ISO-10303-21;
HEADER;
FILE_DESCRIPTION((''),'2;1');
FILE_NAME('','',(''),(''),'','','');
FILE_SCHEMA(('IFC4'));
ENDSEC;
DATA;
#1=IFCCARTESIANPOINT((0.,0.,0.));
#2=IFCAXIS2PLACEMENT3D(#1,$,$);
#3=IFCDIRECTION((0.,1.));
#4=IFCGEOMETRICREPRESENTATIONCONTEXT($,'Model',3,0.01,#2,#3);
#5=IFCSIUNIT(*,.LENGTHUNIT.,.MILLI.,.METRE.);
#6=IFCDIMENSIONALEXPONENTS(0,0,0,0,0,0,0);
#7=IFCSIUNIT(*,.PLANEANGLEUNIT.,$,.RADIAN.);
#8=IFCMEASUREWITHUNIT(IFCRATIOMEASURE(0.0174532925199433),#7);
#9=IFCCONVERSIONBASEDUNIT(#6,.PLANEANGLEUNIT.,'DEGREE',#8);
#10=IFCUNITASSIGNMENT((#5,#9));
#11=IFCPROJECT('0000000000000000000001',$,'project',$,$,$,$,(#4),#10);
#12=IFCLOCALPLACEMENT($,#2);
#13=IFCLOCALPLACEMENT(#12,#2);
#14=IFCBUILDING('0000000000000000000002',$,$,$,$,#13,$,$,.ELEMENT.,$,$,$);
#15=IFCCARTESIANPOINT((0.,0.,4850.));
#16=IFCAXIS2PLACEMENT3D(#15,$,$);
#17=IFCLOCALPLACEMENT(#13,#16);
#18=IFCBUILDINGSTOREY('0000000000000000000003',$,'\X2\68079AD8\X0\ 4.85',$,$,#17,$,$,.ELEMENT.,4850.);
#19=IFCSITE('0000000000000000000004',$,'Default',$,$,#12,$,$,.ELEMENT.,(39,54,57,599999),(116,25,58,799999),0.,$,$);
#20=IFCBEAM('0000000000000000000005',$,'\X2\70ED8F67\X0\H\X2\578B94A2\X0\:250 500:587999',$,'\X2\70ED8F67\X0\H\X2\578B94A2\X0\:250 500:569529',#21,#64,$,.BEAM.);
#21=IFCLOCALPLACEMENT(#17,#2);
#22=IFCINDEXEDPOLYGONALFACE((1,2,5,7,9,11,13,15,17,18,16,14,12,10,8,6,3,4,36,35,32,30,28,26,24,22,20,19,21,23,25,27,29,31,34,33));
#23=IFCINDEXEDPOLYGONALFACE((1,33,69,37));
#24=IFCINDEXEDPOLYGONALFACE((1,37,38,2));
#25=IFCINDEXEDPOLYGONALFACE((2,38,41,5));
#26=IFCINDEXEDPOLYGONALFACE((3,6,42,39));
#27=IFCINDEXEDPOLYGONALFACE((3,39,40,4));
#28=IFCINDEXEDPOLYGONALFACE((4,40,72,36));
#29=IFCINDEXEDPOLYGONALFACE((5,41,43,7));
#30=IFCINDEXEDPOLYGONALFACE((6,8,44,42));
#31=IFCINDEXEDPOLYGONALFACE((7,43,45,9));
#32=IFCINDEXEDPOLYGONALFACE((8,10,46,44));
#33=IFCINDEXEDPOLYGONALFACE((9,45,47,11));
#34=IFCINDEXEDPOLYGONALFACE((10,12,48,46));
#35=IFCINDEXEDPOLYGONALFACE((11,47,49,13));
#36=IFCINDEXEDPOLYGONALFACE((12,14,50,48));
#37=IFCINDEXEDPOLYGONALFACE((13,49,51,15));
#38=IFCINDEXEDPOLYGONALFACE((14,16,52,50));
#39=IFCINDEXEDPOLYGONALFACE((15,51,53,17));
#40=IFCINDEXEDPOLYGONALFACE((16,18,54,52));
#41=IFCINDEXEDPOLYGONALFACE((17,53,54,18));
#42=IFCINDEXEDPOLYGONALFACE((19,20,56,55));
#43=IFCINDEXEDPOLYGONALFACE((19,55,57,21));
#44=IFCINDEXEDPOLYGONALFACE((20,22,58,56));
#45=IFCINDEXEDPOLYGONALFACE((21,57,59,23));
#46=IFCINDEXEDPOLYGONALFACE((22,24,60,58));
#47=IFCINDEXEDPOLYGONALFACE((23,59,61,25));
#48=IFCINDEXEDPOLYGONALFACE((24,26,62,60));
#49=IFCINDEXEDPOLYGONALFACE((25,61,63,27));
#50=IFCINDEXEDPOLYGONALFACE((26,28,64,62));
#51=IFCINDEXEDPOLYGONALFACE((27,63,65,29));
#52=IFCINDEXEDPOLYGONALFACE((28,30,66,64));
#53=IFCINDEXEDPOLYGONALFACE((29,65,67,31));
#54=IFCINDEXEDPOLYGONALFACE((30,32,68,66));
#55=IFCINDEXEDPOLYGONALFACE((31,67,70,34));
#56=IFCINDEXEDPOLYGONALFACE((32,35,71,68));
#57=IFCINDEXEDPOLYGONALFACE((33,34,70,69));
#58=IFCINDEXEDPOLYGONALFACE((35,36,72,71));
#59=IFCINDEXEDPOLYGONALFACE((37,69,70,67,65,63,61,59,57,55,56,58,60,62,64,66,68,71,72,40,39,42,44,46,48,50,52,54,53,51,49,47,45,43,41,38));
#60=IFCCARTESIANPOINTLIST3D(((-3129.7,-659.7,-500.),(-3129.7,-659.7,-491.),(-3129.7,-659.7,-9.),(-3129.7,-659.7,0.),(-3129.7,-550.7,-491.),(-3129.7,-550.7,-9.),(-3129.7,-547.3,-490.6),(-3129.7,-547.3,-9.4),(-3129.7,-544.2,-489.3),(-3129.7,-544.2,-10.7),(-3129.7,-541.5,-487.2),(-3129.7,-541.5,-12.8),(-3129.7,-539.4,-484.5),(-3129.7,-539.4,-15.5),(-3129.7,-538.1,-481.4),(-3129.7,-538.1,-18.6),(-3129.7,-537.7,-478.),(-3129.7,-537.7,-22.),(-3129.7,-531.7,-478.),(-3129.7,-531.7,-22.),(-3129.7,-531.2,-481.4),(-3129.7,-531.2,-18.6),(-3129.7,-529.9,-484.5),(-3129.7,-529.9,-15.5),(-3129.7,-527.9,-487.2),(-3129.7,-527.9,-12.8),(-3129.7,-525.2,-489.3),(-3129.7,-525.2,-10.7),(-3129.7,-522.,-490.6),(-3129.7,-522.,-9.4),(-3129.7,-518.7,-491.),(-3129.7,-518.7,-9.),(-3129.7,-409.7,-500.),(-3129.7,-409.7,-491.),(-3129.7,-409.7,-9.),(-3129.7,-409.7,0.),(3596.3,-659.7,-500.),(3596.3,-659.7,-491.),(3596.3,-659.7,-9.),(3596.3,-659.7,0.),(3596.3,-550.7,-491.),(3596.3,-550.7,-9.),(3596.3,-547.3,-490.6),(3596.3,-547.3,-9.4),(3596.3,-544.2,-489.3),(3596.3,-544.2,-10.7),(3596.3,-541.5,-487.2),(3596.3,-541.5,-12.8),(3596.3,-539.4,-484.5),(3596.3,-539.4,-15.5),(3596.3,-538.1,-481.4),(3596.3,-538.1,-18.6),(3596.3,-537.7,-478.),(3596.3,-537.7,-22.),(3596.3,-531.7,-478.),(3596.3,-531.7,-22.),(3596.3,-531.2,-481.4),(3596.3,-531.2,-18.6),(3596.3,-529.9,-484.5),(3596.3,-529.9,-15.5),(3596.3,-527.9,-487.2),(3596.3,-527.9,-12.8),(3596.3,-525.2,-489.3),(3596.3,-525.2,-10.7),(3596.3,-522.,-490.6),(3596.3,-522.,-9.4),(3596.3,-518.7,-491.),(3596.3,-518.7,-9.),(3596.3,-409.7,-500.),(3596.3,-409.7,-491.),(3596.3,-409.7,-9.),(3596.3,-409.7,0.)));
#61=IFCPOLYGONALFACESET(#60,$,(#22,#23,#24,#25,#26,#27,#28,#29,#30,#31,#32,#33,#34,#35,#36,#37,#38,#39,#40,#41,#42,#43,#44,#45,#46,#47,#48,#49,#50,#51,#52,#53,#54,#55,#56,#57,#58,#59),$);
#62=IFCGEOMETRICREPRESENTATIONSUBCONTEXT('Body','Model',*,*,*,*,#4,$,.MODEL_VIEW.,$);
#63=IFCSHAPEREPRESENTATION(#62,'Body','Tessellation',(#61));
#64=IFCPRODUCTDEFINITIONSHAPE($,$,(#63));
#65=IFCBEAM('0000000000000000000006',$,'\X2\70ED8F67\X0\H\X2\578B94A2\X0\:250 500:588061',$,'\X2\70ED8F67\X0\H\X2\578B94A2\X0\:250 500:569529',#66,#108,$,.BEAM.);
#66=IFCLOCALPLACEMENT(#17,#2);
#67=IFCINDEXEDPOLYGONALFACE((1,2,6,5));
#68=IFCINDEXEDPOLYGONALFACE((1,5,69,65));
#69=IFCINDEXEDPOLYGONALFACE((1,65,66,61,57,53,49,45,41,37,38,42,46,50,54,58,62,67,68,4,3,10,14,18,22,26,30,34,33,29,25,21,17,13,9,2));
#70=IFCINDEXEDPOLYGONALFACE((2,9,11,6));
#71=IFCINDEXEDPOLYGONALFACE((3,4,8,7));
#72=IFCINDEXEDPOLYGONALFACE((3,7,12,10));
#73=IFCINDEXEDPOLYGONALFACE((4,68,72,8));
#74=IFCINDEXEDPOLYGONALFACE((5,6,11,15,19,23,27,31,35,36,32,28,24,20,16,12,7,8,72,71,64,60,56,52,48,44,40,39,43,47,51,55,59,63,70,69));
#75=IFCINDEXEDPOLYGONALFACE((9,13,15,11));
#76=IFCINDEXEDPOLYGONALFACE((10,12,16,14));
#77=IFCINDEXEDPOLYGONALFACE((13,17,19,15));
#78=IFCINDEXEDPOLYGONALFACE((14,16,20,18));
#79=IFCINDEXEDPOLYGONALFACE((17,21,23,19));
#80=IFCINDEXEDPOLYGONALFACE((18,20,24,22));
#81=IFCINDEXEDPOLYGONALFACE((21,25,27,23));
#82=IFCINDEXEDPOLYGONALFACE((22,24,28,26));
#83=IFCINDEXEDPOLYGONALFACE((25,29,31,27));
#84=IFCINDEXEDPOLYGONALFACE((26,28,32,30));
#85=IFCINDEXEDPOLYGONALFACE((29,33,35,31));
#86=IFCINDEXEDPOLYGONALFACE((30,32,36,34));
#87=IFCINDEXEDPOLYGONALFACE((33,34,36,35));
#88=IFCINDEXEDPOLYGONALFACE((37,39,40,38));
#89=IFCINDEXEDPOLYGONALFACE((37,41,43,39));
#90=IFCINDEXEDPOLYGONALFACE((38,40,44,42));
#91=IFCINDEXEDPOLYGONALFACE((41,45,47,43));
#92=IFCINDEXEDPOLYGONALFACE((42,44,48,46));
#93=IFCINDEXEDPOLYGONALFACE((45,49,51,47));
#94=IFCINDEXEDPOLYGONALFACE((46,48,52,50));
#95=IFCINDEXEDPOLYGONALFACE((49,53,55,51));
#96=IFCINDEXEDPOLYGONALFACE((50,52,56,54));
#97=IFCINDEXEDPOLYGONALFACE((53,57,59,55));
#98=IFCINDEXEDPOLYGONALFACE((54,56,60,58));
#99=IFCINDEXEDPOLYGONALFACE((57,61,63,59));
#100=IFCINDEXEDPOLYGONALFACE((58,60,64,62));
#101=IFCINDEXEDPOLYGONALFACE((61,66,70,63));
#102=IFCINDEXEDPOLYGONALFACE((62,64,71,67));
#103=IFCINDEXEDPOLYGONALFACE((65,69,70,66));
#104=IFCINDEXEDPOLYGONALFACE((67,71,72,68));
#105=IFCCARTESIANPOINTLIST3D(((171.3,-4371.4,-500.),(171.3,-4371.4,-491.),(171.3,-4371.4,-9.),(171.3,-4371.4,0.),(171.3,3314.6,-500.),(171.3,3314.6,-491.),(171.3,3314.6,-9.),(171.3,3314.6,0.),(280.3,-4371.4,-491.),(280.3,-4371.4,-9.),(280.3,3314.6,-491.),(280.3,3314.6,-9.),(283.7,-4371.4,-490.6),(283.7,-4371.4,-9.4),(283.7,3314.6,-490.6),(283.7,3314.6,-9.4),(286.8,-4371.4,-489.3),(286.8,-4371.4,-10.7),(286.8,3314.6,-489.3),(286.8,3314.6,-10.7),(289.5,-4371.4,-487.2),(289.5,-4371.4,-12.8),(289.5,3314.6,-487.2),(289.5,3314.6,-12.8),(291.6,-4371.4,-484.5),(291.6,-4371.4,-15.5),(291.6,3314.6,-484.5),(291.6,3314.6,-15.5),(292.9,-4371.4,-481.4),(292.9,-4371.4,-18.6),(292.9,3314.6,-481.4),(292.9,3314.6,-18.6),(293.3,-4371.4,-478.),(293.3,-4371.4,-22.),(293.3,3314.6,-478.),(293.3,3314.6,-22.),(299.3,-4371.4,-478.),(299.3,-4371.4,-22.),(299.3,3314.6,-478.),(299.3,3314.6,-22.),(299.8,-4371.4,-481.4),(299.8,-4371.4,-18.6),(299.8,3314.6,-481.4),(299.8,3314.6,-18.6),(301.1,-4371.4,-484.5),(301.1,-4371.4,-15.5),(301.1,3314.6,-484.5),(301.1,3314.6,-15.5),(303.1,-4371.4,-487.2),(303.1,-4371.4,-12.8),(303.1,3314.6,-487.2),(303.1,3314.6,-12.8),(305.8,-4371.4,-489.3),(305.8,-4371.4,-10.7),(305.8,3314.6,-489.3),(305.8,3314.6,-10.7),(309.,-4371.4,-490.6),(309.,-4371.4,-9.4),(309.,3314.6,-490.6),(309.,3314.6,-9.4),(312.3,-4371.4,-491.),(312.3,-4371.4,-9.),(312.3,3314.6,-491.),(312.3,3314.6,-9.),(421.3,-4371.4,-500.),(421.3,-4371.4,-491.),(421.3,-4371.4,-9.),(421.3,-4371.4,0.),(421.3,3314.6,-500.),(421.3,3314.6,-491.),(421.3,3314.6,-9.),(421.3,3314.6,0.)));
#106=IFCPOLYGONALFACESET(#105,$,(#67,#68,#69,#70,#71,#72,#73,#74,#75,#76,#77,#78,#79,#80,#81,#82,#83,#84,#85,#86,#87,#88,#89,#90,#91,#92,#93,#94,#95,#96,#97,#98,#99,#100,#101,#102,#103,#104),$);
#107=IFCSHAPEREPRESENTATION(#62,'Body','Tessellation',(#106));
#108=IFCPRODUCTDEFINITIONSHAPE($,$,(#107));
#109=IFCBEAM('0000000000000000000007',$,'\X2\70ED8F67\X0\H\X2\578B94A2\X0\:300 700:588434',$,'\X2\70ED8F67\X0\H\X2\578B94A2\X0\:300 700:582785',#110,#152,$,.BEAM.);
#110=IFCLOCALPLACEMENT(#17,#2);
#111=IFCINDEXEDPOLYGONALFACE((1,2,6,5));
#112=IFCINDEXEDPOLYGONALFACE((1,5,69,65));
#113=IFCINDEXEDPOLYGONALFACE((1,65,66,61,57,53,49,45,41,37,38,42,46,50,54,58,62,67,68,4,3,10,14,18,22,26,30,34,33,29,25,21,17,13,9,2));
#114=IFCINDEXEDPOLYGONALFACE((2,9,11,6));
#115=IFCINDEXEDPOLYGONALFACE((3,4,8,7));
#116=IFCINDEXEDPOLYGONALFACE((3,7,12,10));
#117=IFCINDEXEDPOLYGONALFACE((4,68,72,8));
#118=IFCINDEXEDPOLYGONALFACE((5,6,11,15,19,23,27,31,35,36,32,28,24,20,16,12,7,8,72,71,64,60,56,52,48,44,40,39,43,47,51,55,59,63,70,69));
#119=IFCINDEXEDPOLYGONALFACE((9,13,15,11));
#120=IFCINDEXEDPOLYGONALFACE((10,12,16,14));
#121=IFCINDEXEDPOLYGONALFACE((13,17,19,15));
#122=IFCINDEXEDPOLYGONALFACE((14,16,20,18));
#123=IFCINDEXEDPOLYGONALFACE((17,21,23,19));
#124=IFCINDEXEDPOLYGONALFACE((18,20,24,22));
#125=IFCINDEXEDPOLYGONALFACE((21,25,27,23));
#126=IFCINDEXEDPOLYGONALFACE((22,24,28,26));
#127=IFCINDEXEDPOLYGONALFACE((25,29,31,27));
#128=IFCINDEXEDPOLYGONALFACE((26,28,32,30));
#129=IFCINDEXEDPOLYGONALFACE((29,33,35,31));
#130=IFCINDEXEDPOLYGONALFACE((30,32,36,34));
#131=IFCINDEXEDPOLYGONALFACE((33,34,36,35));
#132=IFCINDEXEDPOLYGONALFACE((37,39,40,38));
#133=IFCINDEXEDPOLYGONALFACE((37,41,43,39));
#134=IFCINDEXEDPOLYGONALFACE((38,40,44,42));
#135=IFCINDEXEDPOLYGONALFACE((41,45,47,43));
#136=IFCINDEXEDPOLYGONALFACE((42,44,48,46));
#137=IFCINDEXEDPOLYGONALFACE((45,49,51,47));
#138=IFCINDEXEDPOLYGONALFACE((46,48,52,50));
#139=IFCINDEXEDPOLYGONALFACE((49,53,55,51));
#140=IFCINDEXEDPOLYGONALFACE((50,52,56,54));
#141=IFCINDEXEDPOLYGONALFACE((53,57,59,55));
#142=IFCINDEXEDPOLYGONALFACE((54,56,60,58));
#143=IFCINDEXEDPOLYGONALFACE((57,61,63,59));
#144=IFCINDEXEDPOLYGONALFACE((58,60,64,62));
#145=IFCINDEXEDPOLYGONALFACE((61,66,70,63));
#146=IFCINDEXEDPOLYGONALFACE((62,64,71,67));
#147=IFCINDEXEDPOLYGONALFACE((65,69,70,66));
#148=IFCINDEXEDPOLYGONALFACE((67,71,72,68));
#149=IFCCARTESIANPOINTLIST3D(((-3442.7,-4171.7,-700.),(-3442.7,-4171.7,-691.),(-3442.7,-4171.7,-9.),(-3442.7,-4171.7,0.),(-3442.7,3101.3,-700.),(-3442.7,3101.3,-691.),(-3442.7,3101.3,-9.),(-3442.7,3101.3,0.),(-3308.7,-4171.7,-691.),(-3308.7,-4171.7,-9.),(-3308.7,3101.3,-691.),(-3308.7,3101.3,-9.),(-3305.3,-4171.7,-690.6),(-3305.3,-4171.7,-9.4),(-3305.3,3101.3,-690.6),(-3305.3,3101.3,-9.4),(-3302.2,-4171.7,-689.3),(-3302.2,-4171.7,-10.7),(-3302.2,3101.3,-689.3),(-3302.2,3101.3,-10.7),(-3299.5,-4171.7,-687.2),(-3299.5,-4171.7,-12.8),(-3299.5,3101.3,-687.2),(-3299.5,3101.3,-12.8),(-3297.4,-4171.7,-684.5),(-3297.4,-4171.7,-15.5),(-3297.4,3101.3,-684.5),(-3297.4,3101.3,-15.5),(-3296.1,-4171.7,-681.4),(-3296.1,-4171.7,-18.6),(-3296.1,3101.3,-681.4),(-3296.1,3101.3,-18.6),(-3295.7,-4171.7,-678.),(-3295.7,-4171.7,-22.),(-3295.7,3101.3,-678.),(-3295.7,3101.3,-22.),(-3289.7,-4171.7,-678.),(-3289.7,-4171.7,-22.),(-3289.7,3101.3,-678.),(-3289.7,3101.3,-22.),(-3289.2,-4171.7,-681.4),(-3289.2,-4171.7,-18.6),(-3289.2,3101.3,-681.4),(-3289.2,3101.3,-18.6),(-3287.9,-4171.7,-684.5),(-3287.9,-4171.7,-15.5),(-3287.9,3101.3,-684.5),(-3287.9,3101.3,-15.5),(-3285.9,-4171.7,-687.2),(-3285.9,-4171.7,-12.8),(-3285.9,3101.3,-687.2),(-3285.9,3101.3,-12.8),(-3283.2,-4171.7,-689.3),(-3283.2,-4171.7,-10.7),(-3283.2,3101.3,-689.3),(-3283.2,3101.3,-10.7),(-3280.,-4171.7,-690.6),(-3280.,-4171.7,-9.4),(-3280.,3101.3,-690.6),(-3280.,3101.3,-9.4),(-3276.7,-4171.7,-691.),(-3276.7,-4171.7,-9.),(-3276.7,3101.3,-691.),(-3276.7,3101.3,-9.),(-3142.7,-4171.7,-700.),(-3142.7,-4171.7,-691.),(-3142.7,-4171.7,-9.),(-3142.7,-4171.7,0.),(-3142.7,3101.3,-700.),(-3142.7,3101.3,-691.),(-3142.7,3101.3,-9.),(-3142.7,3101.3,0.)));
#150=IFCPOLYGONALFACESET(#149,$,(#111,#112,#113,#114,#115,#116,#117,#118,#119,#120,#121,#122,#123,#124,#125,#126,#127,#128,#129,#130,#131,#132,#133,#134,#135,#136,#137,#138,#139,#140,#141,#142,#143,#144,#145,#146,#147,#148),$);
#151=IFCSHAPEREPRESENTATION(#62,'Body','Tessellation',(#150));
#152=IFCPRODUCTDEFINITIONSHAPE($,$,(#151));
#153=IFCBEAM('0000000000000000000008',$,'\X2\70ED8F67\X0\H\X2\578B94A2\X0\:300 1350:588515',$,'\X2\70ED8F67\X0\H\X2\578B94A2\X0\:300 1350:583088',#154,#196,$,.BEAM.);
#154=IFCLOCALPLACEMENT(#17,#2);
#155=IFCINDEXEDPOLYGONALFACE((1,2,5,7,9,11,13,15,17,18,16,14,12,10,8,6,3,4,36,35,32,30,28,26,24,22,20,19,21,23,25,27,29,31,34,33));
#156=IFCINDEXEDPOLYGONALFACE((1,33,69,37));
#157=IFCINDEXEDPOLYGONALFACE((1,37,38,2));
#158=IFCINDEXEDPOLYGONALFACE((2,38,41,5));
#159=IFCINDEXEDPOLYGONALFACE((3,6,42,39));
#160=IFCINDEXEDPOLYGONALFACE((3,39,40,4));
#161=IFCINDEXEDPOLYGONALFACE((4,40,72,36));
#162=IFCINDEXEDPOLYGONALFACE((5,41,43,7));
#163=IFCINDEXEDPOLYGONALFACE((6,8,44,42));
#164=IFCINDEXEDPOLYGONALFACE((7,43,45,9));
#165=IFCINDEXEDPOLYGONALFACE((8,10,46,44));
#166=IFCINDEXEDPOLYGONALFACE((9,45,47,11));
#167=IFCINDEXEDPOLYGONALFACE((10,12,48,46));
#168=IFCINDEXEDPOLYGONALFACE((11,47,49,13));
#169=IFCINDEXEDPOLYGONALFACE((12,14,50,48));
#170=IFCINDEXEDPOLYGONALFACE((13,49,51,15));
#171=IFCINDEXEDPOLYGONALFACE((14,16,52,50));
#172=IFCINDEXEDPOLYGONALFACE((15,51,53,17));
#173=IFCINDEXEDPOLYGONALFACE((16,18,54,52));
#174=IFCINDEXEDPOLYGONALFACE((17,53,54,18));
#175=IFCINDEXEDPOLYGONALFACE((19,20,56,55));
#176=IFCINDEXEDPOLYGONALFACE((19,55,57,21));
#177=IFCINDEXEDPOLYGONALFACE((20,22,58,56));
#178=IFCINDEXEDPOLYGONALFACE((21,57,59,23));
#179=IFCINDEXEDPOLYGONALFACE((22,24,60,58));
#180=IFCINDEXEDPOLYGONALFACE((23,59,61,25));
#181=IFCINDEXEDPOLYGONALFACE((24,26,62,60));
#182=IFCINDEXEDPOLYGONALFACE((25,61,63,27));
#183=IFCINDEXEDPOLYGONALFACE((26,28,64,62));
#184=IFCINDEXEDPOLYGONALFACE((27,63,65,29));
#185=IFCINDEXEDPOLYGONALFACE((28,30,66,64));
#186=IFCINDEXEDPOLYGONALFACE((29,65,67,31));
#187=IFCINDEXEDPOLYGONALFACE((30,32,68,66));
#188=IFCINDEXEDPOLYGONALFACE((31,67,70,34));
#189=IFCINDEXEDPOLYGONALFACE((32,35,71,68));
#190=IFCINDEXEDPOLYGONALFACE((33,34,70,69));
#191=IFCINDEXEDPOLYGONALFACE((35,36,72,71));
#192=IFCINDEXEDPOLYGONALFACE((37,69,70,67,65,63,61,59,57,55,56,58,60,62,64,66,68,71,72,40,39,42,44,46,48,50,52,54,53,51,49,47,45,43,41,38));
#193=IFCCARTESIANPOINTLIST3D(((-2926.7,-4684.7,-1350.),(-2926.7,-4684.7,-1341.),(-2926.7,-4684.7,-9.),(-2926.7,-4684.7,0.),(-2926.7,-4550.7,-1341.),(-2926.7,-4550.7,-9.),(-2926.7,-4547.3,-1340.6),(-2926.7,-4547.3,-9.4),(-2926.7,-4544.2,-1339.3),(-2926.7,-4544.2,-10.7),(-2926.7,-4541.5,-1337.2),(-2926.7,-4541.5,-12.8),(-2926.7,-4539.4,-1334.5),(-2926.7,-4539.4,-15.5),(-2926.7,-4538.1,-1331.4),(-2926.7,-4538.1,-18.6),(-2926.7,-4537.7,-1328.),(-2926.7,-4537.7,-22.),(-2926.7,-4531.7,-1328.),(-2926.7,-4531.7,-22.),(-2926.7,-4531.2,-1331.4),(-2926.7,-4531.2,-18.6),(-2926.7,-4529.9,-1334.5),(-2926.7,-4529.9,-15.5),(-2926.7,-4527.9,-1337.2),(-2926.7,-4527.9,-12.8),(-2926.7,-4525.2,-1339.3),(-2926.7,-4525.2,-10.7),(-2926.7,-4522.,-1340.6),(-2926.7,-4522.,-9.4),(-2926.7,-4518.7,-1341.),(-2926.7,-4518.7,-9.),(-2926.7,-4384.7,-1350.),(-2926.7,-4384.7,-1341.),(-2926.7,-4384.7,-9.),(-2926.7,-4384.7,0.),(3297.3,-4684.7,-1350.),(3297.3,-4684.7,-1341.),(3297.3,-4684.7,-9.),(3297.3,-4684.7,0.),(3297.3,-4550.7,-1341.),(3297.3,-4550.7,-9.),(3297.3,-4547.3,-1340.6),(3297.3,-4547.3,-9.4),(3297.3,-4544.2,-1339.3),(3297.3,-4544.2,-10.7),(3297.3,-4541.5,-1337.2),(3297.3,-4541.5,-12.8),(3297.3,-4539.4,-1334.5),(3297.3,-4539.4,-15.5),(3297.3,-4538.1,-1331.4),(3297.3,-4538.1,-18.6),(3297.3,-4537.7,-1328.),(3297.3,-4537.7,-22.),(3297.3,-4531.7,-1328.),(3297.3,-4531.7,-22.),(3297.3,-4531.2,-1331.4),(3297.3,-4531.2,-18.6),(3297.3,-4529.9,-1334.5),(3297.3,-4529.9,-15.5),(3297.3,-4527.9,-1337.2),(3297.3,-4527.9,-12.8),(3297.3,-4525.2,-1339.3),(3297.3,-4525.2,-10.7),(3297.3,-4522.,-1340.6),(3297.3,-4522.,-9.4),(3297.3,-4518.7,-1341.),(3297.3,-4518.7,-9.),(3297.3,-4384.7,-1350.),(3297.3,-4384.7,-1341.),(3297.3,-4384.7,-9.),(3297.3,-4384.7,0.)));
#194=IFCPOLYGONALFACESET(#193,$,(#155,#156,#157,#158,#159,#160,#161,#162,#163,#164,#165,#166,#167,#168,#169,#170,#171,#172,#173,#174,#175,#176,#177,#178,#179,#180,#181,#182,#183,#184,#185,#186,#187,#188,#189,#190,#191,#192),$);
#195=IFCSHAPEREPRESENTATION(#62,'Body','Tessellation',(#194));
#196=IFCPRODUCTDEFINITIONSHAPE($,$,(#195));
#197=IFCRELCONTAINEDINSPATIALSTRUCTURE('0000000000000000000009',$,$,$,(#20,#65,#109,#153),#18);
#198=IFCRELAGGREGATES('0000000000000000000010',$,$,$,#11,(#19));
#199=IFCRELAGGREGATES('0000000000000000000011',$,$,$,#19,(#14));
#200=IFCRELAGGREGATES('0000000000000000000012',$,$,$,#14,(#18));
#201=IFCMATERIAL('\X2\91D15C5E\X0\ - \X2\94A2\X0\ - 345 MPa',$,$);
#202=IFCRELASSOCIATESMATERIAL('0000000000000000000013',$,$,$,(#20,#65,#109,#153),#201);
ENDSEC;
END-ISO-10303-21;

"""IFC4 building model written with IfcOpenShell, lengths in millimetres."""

from ifc_helpers import new_model, entity, si_unit, converted_unit, direction, frame, frame_2d, origin, place, context, subcontext, project, spatial, i_section, extrude, material, element, save


model = new_model("IFC4")

# Units and contexts
model_context = context("Model", 3, precision=0.01, world=origin(), true_north=direction((0.0, 1.0)))
body_context = subcontext(model_context, "Body", "Model", "MODEL_VIEW")
ifc_project = project(units=[si_unit("LENGTHUNIT", "METRE", prefix="MILLI"), converted_unit("PLANEANGLEUNIT", "DEGREE", entity("IfcRatioMeasure", 0.0174532925199433), si_unit("PLANEANGLEUNIT", "RADIAN"), dimensions=[0, 0, 0, 0, 0, 0, 0])], contexts=[model_context])

# Site, building, storey
site_placement = place(None, origin())
site = spatial("IfcSite", under=ifc_project, at=site_placement, Name="Default", CompositionType="ELEMENT", RefLatitude=(39, 54, 57, 599999), RefLongitude=(116, 25, 58, 799999), RefElevation=0.0)
building_placement = place(site_placement, origin())
building = spatial("IfcBuilding", under=site, at=building_placement, CompositionType="ELEMENT")
storey_placement = place(building_placement, frame((0.0, 0.0, 4850.0)))
storey = spatial("IfcBuildingStorey", under=building, at=storey_placement, Name="标高 4.85", CompositionType="ELEMENT", Elevation=4850.0)

# Beams
ifc_material_1 = material(Name="金属 - 钢 - 345 MPa")
beam_1_placement = place(storey_placement, frame((-3292.7, -534.7, 0.0)))
element("IfcBeam", 1, at=beam_1_placement, inside=storey, material=ifc_material_1, Name="热轧H型钢:250 500:587999", ObjectType="热轧H型钢:250 500:569529", PredefinedType="BEAM", context=body_context, shape_type="SweptSolid", body=[
    extrude(i_section(OverallWidth=250.0, OverallDepth=500.0, WebThickness=6.0, FlangeThickness=9.0, FilletRadius=13.0, at=frame_2d((0.0, 0.0), x_axis=(0.0, 1.0))), frame((163.0, 0.0, -250.0), z_axis=(1.0, 0.0, 0.0), x_axis=(0.0, 0.0, -1.0)), (0.0, 0.0, 1.0), 6726.0),
])
beam_2_placement = place(storey_placement, frame((296.3, 3314.9, 0.0), z_axis=(0.0, 0.0, 1.0), x_axis=(0.0, -1.0, 0.0)))
element("IfcBeam", 2, at=beam_2_placement, inside=storey, material=ifc_material_1, Name="热轧H型钢:250 500:588061", ObjectType="热轧H型钢:250 500:569529", PredefinedType="BEAM", context=body_context, shape_type="SweptSolid", body=[
    extrude(i_section(OverallWidth=250.0, OverallDepth=500.0, WebThickness=6.0, FlangeThickness=9.0, FilletRadius=13.0, at=frame_2d((0.0, 0.0), x_axis=(0.0, 1.0))), frame((0.3, 0.0, -250.0), z_axis=(1.0, 0.0, 0.0), x_axis=(0.0, 0.0, -1.0)), (0.0, 0.0, 1.0), 7686.0),
])
beam_3_placement = place(storey_placement, frame((-3292.7, 3115.3, 0.0), z_axis=(0.0, 0.0, 1.0), x_axis=(0.0, -1.0, 0.0)))
element("IfcBeam", 3, at=beam_3_placement, inside=storey, material=ifc_material_1, Name="热轧H型钢:300 700:588434", ObjectType="热轧H型钢:300 700:582785", PredefinedType="BEAM", context=body_context, shape_type="SweptSolid", body=[
    extrude(i_section(OverallWidth=300.0, OverallDepth=700.0, WebThickness=6.0, FlangeThickness=9.0, FilletRadius=13.0, at=frame_2d((0.0, 0.0), x_axis=(0.0, 1.0))), frame((14.0, 0.0, -350.0), z_axis=(1.0, 0.0, 0.0), x_axis=(0.0, 0.0, -1.0)), (0.0, 0.0, 1.0), 7273.0),
])
beam_4_placement = place(storey_placement, frame((-2953.7, -4534.7, 0.0)))
element("IfcBeam", 4, at=beam_4_placement, inside=storey, material=ifc_material_1, Name="热轧H型钢:300 1350:588515", ObjectType="热轧H型钢:300 1350:583088", PredefinedType="BEAM", context=body_context, shape_type="SweptSolid", body=[
    extrude(i_section(OverallWidth=300.0, OverallDepth=1350.0, WebThickness=6.0, FlangeThickness=9.0, FilletRadius=13.0, at=frame_2d((0.0, 0.0), x_axis=(0.0, 1.0))), frame((27.0, 0.0, -675.0), z_axis=(1.0, 0.0, 0.0), x_axis=(0.0, 0.0, -1.0)), (0.0, 0.0, 1.0), 6224.0),
])

save(model, "model.ifc")
